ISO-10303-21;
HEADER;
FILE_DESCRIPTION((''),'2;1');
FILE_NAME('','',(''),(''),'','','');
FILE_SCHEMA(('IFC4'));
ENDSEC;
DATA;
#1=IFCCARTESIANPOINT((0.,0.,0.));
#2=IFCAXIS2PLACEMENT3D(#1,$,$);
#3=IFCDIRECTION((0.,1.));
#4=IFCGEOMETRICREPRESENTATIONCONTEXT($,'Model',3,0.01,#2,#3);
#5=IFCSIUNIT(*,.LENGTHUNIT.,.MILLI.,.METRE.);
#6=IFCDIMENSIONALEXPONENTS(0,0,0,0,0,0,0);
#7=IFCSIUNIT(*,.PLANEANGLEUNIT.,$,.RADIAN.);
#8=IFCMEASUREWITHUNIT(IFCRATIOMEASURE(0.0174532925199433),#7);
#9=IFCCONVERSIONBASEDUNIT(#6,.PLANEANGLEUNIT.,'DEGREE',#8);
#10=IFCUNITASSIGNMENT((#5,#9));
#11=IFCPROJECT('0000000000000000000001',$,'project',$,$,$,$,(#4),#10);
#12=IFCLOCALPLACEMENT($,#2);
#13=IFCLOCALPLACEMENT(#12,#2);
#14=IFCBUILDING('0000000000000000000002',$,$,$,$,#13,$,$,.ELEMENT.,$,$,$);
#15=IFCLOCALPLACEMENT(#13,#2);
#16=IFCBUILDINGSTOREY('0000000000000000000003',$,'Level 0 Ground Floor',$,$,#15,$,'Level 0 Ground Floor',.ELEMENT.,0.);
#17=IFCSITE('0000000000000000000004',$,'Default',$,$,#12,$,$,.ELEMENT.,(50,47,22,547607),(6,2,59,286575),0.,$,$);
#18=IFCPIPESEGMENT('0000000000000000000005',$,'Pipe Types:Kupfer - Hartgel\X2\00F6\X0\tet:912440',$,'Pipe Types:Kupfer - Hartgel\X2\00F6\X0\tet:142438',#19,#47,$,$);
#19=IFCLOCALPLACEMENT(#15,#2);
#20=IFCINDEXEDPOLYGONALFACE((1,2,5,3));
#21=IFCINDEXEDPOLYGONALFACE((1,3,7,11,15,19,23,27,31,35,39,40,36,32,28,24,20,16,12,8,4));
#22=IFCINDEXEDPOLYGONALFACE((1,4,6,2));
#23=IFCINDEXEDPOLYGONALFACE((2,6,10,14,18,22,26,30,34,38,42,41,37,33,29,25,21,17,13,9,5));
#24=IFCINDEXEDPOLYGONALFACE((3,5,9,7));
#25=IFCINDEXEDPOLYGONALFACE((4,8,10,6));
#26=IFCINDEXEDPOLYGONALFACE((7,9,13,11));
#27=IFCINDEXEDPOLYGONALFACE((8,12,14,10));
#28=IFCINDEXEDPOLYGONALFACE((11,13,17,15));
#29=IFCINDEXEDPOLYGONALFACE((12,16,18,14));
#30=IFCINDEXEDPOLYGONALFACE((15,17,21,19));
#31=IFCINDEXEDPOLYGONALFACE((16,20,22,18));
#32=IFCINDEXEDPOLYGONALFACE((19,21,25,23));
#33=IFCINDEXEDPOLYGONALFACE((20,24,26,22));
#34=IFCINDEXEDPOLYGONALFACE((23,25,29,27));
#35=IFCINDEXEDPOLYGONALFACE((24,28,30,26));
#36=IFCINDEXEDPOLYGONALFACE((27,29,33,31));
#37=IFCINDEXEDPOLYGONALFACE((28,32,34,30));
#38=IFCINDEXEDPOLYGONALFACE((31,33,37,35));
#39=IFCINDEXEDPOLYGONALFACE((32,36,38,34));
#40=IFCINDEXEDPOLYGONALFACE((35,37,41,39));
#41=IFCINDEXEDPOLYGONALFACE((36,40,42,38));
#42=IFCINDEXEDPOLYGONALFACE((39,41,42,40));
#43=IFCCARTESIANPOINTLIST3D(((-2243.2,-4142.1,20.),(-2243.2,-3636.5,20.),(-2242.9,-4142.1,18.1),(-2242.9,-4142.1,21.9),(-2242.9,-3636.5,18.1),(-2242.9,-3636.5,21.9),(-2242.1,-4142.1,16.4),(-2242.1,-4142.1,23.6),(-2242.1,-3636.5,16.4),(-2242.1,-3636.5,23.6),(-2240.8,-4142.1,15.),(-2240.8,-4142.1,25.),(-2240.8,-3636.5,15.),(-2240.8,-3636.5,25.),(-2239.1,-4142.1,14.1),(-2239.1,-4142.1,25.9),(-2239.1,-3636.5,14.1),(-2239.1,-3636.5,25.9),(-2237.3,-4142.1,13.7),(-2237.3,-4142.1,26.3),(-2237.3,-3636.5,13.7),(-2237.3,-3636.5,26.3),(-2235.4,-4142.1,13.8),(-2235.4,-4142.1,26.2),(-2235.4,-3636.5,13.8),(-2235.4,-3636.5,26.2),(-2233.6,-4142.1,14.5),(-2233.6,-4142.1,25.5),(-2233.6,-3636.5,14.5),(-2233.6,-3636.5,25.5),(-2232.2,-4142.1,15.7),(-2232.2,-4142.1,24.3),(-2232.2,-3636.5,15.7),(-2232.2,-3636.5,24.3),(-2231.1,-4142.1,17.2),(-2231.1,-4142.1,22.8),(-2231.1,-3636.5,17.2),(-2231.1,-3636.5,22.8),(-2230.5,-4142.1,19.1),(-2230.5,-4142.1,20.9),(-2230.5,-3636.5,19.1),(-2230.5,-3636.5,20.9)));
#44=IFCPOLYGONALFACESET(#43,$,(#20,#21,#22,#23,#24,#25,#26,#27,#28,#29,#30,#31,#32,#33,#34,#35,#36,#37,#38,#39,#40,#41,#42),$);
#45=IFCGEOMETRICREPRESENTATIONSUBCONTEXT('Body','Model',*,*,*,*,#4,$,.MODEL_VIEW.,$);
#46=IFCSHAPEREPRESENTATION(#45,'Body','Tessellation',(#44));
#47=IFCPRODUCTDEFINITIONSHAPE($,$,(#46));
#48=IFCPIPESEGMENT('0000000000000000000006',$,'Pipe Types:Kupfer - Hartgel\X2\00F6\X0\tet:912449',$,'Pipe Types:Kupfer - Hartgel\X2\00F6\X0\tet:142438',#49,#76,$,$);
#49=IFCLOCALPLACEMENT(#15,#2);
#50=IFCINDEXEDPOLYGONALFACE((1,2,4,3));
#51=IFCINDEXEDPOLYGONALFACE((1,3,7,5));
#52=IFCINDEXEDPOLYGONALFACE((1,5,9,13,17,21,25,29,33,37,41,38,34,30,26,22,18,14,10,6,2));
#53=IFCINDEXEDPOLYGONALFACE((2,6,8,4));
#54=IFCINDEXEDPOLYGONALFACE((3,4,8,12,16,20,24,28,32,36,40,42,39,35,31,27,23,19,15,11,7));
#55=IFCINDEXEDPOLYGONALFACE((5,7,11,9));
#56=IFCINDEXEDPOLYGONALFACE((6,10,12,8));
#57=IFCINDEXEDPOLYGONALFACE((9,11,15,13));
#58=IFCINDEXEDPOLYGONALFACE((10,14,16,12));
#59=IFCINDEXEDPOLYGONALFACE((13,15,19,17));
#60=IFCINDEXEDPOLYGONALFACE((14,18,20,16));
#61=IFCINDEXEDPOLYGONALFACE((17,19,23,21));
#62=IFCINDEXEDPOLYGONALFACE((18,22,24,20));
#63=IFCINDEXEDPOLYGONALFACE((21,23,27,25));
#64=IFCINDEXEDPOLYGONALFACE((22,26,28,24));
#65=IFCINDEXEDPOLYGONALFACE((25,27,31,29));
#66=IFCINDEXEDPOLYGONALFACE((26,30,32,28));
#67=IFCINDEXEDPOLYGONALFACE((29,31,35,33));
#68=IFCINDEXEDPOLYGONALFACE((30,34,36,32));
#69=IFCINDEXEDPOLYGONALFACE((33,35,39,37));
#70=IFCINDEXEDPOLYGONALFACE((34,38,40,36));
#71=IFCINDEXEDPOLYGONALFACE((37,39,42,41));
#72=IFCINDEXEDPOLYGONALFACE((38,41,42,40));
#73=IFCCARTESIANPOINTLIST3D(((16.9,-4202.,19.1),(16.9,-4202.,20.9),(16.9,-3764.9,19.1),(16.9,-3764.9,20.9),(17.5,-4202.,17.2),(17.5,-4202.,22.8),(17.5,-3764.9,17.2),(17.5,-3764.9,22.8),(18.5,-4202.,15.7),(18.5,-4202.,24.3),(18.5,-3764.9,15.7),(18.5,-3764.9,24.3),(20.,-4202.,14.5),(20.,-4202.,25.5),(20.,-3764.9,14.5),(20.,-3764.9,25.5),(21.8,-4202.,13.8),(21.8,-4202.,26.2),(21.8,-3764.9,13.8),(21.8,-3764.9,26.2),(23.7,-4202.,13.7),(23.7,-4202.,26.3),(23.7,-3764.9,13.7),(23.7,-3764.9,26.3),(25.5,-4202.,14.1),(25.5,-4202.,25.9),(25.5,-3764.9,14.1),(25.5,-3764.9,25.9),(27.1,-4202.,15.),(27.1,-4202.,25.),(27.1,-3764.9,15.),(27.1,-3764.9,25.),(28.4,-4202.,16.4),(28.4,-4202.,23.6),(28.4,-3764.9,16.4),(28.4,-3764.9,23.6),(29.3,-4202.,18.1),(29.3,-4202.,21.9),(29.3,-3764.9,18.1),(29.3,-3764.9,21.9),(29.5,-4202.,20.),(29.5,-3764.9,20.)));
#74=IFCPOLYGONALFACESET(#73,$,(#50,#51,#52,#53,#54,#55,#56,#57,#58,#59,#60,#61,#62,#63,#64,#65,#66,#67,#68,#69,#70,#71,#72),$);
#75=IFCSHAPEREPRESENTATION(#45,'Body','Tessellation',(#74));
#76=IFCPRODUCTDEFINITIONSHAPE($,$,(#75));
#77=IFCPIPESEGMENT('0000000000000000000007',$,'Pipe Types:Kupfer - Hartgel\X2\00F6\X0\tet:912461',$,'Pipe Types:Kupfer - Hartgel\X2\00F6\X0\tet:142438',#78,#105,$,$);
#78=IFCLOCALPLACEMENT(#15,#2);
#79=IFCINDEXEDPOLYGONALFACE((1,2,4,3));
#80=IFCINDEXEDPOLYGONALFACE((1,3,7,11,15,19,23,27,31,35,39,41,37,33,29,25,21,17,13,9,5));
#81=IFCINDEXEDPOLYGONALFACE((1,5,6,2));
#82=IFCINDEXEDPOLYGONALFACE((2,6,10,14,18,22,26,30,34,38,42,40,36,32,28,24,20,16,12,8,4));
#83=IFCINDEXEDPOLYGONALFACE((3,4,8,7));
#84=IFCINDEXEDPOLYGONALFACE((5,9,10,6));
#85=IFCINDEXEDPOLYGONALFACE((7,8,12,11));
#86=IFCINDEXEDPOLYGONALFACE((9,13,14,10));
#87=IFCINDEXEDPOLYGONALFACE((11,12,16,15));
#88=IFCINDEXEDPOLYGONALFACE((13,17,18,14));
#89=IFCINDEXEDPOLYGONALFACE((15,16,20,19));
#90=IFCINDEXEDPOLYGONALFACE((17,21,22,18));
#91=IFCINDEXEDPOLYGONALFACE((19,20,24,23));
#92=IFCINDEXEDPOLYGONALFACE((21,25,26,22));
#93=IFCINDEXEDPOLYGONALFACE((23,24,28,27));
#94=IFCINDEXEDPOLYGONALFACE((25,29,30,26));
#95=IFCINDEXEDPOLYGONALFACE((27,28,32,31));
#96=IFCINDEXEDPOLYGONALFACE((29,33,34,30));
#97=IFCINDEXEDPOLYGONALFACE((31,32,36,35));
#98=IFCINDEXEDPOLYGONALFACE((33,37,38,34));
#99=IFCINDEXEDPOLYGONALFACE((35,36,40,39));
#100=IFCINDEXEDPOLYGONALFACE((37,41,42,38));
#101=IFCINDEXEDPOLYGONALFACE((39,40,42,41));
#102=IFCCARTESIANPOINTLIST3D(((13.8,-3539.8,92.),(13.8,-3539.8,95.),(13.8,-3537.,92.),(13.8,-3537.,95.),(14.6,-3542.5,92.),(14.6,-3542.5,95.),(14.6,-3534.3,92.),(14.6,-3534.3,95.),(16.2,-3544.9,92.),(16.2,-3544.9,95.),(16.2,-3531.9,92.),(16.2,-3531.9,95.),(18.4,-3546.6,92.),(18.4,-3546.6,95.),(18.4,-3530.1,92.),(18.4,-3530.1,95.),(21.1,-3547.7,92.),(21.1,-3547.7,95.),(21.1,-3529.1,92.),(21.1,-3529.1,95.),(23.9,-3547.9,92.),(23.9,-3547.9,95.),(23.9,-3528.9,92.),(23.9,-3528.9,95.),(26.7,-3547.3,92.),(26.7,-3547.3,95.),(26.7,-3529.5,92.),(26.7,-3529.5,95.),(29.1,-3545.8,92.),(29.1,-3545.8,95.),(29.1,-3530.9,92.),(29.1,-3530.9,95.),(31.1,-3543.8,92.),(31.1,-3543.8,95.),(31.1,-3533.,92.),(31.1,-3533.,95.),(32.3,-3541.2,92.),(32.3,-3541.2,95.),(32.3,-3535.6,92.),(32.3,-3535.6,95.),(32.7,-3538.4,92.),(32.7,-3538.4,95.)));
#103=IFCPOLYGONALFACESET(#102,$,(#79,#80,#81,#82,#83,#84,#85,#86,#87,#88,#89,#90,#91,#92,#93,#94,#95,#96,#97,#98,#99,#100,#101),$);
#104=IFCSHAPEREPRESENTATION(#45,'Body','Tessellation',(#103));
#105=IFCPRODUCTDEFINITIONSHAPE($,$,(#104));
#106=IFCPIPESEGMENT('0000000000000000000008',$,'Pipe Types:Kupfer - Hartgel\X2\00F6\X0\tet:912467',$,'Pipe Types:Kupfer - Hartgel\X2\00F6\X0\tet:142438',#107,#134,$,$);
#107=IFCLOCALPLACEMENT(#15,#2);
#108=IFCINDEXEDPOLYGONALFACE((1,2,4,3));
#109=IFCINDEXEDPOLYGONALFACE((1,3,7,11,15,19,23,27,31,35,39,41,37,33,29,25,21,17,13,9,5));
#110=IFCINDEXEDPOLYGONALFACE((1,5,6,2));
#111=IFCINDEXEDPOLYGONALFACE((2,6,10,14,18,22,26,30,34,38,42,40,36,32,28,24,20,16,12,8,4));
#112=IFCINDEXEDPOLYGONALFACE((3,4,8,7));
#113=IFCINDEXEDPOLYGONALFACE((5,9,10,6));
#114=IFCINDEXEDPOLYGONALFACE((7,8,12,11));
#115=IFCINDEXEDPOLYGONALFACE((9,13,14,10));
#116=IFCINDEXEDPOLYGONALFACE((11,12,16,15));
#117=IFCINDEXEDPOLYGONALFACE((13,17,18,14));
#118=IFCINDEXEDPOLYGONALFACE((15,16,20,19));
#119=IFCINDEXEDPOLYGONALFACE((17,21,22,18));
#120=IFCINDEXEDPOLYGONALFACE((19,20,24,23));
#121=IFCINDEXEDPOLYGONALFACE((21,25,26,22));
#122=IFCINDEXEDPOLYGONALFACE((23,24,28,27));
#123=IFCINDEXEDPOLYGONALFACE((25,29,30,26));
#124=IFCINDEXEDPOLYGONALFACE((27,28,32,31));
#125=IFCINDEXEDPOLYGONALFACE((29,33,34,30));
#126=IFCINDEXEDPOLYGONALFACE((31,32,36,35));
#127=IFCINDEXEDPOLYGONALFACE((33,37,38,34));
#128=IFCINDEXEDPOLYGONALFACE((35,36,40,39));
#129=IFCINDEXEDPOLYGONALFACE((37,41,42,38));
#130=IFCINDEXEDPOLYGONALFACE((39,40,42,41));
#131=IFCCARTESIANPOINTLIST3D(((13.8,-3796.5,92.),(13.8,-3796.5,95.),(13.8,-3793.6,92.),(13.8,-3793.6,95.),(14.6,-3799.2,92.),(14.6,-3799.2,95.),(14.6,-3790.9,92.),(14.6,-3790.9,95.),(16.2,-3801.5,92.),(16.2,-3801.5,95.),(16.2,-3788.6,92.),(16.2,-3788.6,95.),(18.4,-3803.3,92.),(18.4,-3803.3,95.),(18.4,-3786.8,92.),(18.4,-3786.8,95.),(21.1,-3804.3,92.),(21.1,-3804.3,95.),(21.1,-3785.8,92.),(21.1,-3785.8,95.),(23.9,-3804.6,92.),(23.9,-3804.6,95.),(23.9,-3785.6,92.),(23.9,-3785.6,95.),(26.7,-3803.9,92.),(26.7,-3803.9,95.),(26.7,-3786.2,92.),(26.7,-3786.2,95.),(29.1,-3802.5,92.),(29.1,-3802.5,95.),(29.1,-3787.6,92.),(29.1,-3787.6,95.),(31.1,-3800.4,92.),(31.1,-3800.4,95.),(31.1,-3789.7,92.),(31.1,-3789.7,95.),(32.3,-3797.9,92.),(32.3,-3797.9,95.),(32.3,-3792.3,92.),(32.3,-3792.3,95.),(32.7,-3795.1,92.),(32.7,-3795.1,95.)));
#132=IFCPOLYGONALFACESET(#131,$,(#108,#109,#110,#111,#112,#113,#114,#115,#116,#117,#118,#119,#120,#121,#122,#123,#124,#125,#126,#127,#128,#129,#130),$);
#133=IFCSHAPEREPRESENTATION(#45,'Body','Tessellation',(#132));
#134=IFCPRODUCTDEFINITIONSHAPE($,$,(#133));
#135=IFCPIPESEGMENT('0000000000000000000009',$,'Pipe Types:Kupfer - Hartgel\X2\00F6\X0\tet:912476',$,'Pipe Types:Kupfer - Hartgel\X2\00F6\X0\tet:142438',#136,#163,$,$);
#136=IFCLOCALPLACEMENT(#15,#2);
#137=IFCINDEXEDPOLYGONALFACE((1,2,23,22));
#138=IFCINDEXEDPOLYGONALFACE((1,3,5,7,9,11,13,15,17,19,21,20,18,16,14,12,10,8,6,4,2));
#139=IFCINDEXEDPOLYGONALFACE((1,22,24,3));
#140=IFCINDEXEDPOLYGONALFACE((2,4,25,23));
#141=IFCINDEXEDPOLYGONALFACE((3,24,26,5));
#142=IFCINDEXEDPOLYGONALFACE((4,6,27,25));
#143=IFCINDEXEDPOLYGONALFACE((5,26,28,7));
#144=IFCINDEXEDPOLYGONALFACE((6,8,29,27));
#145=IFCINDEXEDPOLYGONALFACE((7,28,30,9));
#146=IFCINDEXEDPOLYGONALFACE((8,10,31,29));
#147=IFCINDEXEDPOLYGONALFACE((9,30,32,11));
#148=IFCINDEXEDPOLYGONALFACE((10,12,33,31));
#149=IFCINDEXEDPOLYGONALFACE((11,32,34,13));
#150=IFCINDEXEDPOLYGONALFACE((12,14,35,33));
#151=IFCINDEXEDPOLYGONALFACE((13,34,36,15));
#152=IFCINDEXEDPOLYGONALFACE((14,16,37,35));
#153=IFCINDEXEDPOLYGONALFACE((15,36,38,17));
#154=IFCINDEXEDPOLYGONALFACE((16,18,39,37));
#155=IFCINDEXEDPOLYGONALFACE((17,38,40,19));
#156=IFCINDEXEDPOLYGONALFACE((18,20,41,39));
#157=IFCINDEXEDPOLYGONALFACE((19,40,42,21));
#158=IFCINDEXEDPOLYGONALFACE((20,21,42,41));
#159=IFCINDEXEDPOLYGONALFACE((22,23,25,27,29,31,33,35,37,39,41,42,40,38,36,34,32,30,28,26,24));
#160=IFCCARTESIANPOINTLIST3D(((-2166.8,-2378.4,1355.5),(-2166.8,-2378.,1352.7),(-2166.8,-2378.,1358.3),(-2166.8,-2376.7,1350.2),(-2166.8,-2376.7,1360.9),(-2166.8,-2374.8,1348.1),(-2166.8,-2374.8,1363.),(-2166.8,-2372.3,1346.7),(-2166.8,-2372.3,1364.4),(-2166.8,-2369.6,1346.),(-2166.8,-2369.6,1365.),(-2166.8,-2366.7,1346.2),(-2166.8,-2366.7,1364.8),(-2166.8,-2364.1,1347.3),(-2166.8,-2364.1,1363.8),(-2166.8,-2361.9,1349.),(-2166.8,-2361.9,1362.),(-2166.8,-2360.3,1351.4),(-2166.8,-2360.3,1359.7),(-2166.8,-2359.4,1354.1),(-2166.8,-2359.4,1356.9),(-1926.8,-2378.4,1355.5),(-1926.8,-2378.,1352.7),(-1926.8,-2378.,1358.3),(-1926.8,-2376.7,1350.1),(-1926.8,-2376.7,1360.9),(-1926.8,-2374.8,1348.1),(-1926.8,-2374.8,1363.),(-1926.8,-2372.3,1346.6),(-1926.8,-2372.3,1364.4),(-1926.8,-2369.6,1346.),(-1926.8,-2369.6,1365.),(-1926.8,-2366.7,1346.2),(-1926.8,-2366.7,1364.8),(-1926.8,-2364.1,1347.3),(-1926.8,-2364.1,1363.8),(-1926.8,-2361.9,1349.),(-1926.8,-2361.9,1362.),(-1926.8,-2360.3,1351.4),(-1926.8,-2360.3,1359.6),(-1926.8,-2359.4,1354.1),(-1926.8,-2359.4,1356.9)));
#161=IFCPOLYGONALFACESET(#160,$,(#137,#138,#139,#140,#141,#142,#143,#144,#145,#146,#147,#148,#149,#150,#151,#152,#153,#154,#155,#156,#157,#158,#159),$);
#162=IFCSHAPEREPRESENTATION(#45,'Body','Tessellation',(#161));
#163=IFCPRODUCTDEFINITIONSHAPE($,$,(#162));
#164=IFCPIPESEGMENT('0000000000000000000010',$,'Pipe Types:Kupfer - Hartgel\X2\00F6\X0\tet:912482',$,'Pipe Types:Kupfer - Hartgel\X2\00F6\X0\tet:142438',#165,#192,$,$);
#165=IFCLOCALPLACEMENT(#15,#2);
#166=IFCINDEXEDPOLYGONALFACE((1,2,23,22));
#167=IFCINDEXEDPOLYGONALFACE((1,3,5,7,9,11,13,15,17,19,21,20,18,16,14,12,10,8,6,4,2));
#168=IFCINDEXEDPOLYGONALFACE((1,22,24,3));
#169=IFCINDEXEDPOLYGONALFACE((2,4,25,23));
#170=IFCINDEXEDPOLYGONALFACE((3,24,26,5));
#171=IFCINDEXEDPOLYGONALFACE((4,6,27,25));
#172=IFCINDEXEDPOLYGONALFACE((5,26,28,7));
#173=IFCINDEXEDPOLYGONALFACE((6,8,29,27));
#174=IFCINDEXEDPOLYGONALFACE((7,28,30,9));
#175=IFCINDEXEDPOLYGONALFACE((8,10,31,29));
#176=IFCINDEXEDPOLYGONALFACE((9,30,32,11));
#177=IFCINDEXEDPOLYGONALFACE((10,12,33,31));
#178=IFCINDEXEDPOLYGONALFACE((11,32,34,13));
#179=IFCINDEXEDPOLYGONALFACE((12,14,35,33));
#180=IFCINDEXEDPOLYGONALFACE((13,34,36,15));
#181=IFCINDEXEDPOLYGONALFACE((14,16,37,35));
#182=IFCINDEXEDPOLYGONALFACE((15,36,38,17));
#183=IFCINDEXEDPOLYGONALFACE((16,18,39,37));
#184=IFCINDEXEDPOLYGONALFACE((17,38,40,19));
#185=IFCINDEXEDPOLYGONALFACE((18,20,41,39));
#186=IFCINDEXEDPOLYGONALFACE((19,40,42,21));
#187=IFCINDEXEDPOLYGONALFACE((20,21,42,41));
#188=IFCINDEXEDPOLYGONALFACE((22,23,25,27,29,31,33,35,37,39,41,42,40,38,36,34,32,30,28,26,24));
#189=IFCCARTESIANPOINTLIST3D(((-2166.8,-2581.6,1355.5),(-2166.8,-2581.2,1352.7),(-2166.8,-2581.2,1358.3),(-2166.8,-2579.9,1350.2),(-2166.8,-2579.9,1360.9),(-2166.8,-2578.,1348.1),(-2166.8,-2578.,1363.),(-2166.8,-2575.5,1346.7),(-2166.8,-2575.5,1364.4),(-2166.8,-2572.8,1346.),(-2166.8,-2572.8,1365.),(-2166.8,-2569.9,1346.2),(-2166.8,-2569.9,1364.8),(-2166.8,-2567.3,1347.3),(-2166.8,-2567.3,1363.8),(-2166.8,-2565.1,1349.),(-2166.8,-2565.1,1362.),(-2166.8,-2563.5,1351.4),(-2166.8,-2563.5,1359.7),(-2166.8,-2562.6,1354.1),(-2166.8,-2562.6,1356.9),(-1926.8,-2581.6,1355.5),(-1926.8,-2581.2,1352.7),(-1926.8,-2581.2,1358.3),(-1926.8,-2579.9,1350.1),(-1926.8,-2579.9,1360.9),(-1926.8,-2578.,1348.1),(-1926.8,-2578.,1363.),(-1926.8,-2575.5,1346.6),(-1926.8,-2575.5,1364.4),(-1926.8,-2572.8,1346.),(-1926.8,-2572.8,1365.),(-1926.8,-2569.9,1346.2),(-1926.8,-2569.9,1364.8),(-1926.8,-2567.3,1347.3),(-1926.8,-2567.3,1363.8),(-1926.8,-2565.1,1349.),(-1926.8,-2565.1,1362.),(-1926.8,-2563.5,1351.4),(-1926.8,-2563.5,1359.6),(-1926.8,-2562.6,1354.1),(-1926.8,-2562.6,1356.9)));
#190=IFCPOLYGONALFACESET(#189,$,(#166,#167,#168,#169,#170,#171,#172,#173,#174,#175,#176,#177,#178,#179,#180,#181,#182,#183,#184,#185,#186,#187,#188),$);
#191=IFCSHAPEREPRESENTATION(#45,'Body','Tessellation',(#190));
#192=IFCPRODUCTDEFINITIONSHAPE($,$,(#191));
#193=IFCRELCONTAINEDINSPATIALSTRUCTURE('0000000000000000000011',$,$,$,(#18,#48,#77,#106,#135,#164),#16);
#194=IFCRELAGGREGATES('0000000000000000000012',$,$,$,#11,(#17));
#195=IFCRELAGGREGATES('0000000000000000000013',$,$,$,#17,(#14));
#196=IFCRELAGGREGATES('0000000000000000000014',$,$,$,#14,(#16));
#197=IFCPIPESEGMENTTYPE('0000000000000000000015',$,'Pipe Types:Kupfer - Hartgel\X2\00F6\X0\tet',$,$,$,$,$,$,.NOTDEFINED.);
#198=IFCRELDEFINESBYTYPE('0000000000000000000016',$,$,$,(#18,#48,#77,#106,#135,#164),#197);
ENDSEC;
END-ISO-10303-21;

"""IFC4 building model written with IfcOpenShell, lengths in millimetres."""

from ifc_helpers import new_model, entity, si_unit, converted_unit, direction, frame, frame_2d, origin, origin_2d_with_axis, place, context, subcontext, project, spatial, circle, extrude, type_object, element, save


model = new_model("IFC4")

# Units and contexts
model_context = context("Model", 3, precision=0.01, world=origin(), true_north=direction((0.0, 1.0)))
body_context = subcontext(model_context, "Body", "Model", "MODEL_VIEW")
ifc_project = project(units=[si_unit("LENGTHUNIT", "METRE", prefix="MILLI"), converted_unit("PLANEANGLEUNIT", "DEGREE", entity("IfcRatioMeasure", 0.0174532925199433), si_unit("PLANEANGLEUNIT", "RADIAN"), dimensions=[0, 0, 0, 0, 0, 0, 0])], contexts=[model_context])

# Site, building, storey
site_placement = place(None, origin())
site = spatial("IfcSite", under=ifc_project, at=site_placement, Name="Default", CompositionType="ELEMENT", RefLatitude=(50, 47, 22, 547607), RefLongitude=(6, 2, 59, 286575), RefElevation=0.0)
building_placement = place(site_placement, origin())
building = spatial("IfcBuilding", under=site, at=building_placement, CompositionType="ELEMENT")
storey_placement = place(building_placement, origin())
storey = spatial("IfcBuildingStorey", under=building, at=storey_placement, Name="Level 0 Ground Floor", LongName="Level 0 Ground Floor", CompositionType="ELEMENT", Elevation=0.0)

# Pipe segments
pipe_segment_type = type_object("IfcPipeSegmentType", Name="Pipe Types:Kupfer - Hartgelötet", PredefinedType="NOTDEFINED")
pipe_segment_1_placement = place(storey_placement, frame((-2244.8, -4142.1, 12.1)))
element("IfcPipeSegment", 1, at=pipe_segment_1_placement, inside=storey, type_object=pipe_segment_type, Name="Pipe Types:Kupfer - Hartgelötet:912440", ObjectType="Pipe Types:Kupfer - Hartgelötet:142438", context=body_context, shape_type="SweptSolid", body=[
    extrude(circle(Radius=6.3, at=frame_2d((0.0, 0.0), x_axis=(1.0, 0.0))), frame((7.9, 0.0, 7.9), z_axis=(0.0, 1.0, 0.0), x_axis=(-1.0, 0.0, 0.0)), (0.0, 0.0, 1.0), 505.5),
])
pipe_segment_2_placement = place(storey_placement, frame((15.2, -4202.0, 12.1)))
element("IfcPipeSegment", 2, at=pipe_segment_2_placement, inside=storey, type_object=pipe_segment_type, Name="Pipe Types:Kupfer - Hartgelötet:912449", ObjectType="Pipe Types:Kupfer - Hartgelötet:142438", context=body_context, shape_type="SweptSolid", body=[
    extrude(circle(Radius=6.3, at=frame_2d((0.0, 0.0), x_axis=(1.0, 0.0))), frame((7.9, 0.0, 7.9), z_axis=(0.0, 1.0, 0.0), x_axis=(1.0, 0.0, 0.0)), (0.0, 0.0, 1.0), 437.1),
])
pipe_segment_3_placement = place(storey_placement, frame((12.1, -3549.5, 92.0)))
element("IfcPipeSegment", 3, at=pipe_segment_3_placement, inside=storey, type_object=pipe_segment_type, Name="Pipe Types:Kupfer - Hartgelötet:912461", ObjectType="Pipe Types:Kupfer - Hartgelötet:142438", context=body_context, shape_type="SweptSolid", body=[
    extrude(circle(Radius=9.5, at=frame_2d((0.0, 0.0), x_axis=(1.0, 0.0))), frame((11.1, 11.1, 0.0)), (0.0, 0.0, 1.0), 3.0),
])
pipe_segment_4_placement = place(storey_placement, frame((12.1, -3806.2, 92.0)))
element("IfcPipeSegment", 4, at=pipe_segment_4_placement, inside=storey, type_object=pipe_segment_type, Name="Pipe Types:Kupfer - Hartgelötet:912467", ObjectType="Pipe Types:Kupfer - Hartgelötet:142438", context=body_context, shape_type="SweptSolid", body=[
    extrude(circle(Radius=9.5, at=frame_2d((0.0, 0.0), x_axis=(1.0, 0.0))), frame((11.1, 11.1, 0.0)), (0.0, 0.0, 1.0), 3.0),
])
pipe_segment_5_placement = place(storey_placement, frame((-2166.8, -2380.0, 1344.4)))
element("IfcPipeSegment", 5, at=pipe_segment_5_placement, inside=storey, type_object=pipe_segment_type, Name="Pipe Types:Kupfer - Hartgelötet:912476", ObjectType="Pipe Types:Kupfer - Hartgelötet:142438", context=body_context, shape_type="SweptSolid", body=[
    extrude(circle(Radius=9.5, at=origin_2d_with_axis()), frame((0.0, 11.1, 11.1), z_axis=(1.0, 0.0, -0.000089), x_axis=(0.0, -1.0, 0.0)), (0.0, 0.0, 1.0), 240.0),
])
pipe_segment_6_placement = place(storey_placement, frame((-2166.8, -2583.2, 1344.4)))
element("IfcPipeSegment", 6, at=pipe_segment_6_placement, inside=storey, type_object=pipe_segment_type, Name="Pipe Types:Kupfer - Hartgelötet:912482", ObjectType="Pipe Types:Kupfer - Hartgelötet:142438", context=body_context, shape_type="SweptSolid", body=[
    extrude(circle(Radius=9.5, at=origin_2d_with_axis()), frame((240.0, 11.1, 11.1), z_axis=(-1.0, 0.0, 0.000076), x_axis=(0.0, -1.0, 0.0)), (0.0, 0.0, 1.0), 240.0),
])

save(model, "model.ifc")
